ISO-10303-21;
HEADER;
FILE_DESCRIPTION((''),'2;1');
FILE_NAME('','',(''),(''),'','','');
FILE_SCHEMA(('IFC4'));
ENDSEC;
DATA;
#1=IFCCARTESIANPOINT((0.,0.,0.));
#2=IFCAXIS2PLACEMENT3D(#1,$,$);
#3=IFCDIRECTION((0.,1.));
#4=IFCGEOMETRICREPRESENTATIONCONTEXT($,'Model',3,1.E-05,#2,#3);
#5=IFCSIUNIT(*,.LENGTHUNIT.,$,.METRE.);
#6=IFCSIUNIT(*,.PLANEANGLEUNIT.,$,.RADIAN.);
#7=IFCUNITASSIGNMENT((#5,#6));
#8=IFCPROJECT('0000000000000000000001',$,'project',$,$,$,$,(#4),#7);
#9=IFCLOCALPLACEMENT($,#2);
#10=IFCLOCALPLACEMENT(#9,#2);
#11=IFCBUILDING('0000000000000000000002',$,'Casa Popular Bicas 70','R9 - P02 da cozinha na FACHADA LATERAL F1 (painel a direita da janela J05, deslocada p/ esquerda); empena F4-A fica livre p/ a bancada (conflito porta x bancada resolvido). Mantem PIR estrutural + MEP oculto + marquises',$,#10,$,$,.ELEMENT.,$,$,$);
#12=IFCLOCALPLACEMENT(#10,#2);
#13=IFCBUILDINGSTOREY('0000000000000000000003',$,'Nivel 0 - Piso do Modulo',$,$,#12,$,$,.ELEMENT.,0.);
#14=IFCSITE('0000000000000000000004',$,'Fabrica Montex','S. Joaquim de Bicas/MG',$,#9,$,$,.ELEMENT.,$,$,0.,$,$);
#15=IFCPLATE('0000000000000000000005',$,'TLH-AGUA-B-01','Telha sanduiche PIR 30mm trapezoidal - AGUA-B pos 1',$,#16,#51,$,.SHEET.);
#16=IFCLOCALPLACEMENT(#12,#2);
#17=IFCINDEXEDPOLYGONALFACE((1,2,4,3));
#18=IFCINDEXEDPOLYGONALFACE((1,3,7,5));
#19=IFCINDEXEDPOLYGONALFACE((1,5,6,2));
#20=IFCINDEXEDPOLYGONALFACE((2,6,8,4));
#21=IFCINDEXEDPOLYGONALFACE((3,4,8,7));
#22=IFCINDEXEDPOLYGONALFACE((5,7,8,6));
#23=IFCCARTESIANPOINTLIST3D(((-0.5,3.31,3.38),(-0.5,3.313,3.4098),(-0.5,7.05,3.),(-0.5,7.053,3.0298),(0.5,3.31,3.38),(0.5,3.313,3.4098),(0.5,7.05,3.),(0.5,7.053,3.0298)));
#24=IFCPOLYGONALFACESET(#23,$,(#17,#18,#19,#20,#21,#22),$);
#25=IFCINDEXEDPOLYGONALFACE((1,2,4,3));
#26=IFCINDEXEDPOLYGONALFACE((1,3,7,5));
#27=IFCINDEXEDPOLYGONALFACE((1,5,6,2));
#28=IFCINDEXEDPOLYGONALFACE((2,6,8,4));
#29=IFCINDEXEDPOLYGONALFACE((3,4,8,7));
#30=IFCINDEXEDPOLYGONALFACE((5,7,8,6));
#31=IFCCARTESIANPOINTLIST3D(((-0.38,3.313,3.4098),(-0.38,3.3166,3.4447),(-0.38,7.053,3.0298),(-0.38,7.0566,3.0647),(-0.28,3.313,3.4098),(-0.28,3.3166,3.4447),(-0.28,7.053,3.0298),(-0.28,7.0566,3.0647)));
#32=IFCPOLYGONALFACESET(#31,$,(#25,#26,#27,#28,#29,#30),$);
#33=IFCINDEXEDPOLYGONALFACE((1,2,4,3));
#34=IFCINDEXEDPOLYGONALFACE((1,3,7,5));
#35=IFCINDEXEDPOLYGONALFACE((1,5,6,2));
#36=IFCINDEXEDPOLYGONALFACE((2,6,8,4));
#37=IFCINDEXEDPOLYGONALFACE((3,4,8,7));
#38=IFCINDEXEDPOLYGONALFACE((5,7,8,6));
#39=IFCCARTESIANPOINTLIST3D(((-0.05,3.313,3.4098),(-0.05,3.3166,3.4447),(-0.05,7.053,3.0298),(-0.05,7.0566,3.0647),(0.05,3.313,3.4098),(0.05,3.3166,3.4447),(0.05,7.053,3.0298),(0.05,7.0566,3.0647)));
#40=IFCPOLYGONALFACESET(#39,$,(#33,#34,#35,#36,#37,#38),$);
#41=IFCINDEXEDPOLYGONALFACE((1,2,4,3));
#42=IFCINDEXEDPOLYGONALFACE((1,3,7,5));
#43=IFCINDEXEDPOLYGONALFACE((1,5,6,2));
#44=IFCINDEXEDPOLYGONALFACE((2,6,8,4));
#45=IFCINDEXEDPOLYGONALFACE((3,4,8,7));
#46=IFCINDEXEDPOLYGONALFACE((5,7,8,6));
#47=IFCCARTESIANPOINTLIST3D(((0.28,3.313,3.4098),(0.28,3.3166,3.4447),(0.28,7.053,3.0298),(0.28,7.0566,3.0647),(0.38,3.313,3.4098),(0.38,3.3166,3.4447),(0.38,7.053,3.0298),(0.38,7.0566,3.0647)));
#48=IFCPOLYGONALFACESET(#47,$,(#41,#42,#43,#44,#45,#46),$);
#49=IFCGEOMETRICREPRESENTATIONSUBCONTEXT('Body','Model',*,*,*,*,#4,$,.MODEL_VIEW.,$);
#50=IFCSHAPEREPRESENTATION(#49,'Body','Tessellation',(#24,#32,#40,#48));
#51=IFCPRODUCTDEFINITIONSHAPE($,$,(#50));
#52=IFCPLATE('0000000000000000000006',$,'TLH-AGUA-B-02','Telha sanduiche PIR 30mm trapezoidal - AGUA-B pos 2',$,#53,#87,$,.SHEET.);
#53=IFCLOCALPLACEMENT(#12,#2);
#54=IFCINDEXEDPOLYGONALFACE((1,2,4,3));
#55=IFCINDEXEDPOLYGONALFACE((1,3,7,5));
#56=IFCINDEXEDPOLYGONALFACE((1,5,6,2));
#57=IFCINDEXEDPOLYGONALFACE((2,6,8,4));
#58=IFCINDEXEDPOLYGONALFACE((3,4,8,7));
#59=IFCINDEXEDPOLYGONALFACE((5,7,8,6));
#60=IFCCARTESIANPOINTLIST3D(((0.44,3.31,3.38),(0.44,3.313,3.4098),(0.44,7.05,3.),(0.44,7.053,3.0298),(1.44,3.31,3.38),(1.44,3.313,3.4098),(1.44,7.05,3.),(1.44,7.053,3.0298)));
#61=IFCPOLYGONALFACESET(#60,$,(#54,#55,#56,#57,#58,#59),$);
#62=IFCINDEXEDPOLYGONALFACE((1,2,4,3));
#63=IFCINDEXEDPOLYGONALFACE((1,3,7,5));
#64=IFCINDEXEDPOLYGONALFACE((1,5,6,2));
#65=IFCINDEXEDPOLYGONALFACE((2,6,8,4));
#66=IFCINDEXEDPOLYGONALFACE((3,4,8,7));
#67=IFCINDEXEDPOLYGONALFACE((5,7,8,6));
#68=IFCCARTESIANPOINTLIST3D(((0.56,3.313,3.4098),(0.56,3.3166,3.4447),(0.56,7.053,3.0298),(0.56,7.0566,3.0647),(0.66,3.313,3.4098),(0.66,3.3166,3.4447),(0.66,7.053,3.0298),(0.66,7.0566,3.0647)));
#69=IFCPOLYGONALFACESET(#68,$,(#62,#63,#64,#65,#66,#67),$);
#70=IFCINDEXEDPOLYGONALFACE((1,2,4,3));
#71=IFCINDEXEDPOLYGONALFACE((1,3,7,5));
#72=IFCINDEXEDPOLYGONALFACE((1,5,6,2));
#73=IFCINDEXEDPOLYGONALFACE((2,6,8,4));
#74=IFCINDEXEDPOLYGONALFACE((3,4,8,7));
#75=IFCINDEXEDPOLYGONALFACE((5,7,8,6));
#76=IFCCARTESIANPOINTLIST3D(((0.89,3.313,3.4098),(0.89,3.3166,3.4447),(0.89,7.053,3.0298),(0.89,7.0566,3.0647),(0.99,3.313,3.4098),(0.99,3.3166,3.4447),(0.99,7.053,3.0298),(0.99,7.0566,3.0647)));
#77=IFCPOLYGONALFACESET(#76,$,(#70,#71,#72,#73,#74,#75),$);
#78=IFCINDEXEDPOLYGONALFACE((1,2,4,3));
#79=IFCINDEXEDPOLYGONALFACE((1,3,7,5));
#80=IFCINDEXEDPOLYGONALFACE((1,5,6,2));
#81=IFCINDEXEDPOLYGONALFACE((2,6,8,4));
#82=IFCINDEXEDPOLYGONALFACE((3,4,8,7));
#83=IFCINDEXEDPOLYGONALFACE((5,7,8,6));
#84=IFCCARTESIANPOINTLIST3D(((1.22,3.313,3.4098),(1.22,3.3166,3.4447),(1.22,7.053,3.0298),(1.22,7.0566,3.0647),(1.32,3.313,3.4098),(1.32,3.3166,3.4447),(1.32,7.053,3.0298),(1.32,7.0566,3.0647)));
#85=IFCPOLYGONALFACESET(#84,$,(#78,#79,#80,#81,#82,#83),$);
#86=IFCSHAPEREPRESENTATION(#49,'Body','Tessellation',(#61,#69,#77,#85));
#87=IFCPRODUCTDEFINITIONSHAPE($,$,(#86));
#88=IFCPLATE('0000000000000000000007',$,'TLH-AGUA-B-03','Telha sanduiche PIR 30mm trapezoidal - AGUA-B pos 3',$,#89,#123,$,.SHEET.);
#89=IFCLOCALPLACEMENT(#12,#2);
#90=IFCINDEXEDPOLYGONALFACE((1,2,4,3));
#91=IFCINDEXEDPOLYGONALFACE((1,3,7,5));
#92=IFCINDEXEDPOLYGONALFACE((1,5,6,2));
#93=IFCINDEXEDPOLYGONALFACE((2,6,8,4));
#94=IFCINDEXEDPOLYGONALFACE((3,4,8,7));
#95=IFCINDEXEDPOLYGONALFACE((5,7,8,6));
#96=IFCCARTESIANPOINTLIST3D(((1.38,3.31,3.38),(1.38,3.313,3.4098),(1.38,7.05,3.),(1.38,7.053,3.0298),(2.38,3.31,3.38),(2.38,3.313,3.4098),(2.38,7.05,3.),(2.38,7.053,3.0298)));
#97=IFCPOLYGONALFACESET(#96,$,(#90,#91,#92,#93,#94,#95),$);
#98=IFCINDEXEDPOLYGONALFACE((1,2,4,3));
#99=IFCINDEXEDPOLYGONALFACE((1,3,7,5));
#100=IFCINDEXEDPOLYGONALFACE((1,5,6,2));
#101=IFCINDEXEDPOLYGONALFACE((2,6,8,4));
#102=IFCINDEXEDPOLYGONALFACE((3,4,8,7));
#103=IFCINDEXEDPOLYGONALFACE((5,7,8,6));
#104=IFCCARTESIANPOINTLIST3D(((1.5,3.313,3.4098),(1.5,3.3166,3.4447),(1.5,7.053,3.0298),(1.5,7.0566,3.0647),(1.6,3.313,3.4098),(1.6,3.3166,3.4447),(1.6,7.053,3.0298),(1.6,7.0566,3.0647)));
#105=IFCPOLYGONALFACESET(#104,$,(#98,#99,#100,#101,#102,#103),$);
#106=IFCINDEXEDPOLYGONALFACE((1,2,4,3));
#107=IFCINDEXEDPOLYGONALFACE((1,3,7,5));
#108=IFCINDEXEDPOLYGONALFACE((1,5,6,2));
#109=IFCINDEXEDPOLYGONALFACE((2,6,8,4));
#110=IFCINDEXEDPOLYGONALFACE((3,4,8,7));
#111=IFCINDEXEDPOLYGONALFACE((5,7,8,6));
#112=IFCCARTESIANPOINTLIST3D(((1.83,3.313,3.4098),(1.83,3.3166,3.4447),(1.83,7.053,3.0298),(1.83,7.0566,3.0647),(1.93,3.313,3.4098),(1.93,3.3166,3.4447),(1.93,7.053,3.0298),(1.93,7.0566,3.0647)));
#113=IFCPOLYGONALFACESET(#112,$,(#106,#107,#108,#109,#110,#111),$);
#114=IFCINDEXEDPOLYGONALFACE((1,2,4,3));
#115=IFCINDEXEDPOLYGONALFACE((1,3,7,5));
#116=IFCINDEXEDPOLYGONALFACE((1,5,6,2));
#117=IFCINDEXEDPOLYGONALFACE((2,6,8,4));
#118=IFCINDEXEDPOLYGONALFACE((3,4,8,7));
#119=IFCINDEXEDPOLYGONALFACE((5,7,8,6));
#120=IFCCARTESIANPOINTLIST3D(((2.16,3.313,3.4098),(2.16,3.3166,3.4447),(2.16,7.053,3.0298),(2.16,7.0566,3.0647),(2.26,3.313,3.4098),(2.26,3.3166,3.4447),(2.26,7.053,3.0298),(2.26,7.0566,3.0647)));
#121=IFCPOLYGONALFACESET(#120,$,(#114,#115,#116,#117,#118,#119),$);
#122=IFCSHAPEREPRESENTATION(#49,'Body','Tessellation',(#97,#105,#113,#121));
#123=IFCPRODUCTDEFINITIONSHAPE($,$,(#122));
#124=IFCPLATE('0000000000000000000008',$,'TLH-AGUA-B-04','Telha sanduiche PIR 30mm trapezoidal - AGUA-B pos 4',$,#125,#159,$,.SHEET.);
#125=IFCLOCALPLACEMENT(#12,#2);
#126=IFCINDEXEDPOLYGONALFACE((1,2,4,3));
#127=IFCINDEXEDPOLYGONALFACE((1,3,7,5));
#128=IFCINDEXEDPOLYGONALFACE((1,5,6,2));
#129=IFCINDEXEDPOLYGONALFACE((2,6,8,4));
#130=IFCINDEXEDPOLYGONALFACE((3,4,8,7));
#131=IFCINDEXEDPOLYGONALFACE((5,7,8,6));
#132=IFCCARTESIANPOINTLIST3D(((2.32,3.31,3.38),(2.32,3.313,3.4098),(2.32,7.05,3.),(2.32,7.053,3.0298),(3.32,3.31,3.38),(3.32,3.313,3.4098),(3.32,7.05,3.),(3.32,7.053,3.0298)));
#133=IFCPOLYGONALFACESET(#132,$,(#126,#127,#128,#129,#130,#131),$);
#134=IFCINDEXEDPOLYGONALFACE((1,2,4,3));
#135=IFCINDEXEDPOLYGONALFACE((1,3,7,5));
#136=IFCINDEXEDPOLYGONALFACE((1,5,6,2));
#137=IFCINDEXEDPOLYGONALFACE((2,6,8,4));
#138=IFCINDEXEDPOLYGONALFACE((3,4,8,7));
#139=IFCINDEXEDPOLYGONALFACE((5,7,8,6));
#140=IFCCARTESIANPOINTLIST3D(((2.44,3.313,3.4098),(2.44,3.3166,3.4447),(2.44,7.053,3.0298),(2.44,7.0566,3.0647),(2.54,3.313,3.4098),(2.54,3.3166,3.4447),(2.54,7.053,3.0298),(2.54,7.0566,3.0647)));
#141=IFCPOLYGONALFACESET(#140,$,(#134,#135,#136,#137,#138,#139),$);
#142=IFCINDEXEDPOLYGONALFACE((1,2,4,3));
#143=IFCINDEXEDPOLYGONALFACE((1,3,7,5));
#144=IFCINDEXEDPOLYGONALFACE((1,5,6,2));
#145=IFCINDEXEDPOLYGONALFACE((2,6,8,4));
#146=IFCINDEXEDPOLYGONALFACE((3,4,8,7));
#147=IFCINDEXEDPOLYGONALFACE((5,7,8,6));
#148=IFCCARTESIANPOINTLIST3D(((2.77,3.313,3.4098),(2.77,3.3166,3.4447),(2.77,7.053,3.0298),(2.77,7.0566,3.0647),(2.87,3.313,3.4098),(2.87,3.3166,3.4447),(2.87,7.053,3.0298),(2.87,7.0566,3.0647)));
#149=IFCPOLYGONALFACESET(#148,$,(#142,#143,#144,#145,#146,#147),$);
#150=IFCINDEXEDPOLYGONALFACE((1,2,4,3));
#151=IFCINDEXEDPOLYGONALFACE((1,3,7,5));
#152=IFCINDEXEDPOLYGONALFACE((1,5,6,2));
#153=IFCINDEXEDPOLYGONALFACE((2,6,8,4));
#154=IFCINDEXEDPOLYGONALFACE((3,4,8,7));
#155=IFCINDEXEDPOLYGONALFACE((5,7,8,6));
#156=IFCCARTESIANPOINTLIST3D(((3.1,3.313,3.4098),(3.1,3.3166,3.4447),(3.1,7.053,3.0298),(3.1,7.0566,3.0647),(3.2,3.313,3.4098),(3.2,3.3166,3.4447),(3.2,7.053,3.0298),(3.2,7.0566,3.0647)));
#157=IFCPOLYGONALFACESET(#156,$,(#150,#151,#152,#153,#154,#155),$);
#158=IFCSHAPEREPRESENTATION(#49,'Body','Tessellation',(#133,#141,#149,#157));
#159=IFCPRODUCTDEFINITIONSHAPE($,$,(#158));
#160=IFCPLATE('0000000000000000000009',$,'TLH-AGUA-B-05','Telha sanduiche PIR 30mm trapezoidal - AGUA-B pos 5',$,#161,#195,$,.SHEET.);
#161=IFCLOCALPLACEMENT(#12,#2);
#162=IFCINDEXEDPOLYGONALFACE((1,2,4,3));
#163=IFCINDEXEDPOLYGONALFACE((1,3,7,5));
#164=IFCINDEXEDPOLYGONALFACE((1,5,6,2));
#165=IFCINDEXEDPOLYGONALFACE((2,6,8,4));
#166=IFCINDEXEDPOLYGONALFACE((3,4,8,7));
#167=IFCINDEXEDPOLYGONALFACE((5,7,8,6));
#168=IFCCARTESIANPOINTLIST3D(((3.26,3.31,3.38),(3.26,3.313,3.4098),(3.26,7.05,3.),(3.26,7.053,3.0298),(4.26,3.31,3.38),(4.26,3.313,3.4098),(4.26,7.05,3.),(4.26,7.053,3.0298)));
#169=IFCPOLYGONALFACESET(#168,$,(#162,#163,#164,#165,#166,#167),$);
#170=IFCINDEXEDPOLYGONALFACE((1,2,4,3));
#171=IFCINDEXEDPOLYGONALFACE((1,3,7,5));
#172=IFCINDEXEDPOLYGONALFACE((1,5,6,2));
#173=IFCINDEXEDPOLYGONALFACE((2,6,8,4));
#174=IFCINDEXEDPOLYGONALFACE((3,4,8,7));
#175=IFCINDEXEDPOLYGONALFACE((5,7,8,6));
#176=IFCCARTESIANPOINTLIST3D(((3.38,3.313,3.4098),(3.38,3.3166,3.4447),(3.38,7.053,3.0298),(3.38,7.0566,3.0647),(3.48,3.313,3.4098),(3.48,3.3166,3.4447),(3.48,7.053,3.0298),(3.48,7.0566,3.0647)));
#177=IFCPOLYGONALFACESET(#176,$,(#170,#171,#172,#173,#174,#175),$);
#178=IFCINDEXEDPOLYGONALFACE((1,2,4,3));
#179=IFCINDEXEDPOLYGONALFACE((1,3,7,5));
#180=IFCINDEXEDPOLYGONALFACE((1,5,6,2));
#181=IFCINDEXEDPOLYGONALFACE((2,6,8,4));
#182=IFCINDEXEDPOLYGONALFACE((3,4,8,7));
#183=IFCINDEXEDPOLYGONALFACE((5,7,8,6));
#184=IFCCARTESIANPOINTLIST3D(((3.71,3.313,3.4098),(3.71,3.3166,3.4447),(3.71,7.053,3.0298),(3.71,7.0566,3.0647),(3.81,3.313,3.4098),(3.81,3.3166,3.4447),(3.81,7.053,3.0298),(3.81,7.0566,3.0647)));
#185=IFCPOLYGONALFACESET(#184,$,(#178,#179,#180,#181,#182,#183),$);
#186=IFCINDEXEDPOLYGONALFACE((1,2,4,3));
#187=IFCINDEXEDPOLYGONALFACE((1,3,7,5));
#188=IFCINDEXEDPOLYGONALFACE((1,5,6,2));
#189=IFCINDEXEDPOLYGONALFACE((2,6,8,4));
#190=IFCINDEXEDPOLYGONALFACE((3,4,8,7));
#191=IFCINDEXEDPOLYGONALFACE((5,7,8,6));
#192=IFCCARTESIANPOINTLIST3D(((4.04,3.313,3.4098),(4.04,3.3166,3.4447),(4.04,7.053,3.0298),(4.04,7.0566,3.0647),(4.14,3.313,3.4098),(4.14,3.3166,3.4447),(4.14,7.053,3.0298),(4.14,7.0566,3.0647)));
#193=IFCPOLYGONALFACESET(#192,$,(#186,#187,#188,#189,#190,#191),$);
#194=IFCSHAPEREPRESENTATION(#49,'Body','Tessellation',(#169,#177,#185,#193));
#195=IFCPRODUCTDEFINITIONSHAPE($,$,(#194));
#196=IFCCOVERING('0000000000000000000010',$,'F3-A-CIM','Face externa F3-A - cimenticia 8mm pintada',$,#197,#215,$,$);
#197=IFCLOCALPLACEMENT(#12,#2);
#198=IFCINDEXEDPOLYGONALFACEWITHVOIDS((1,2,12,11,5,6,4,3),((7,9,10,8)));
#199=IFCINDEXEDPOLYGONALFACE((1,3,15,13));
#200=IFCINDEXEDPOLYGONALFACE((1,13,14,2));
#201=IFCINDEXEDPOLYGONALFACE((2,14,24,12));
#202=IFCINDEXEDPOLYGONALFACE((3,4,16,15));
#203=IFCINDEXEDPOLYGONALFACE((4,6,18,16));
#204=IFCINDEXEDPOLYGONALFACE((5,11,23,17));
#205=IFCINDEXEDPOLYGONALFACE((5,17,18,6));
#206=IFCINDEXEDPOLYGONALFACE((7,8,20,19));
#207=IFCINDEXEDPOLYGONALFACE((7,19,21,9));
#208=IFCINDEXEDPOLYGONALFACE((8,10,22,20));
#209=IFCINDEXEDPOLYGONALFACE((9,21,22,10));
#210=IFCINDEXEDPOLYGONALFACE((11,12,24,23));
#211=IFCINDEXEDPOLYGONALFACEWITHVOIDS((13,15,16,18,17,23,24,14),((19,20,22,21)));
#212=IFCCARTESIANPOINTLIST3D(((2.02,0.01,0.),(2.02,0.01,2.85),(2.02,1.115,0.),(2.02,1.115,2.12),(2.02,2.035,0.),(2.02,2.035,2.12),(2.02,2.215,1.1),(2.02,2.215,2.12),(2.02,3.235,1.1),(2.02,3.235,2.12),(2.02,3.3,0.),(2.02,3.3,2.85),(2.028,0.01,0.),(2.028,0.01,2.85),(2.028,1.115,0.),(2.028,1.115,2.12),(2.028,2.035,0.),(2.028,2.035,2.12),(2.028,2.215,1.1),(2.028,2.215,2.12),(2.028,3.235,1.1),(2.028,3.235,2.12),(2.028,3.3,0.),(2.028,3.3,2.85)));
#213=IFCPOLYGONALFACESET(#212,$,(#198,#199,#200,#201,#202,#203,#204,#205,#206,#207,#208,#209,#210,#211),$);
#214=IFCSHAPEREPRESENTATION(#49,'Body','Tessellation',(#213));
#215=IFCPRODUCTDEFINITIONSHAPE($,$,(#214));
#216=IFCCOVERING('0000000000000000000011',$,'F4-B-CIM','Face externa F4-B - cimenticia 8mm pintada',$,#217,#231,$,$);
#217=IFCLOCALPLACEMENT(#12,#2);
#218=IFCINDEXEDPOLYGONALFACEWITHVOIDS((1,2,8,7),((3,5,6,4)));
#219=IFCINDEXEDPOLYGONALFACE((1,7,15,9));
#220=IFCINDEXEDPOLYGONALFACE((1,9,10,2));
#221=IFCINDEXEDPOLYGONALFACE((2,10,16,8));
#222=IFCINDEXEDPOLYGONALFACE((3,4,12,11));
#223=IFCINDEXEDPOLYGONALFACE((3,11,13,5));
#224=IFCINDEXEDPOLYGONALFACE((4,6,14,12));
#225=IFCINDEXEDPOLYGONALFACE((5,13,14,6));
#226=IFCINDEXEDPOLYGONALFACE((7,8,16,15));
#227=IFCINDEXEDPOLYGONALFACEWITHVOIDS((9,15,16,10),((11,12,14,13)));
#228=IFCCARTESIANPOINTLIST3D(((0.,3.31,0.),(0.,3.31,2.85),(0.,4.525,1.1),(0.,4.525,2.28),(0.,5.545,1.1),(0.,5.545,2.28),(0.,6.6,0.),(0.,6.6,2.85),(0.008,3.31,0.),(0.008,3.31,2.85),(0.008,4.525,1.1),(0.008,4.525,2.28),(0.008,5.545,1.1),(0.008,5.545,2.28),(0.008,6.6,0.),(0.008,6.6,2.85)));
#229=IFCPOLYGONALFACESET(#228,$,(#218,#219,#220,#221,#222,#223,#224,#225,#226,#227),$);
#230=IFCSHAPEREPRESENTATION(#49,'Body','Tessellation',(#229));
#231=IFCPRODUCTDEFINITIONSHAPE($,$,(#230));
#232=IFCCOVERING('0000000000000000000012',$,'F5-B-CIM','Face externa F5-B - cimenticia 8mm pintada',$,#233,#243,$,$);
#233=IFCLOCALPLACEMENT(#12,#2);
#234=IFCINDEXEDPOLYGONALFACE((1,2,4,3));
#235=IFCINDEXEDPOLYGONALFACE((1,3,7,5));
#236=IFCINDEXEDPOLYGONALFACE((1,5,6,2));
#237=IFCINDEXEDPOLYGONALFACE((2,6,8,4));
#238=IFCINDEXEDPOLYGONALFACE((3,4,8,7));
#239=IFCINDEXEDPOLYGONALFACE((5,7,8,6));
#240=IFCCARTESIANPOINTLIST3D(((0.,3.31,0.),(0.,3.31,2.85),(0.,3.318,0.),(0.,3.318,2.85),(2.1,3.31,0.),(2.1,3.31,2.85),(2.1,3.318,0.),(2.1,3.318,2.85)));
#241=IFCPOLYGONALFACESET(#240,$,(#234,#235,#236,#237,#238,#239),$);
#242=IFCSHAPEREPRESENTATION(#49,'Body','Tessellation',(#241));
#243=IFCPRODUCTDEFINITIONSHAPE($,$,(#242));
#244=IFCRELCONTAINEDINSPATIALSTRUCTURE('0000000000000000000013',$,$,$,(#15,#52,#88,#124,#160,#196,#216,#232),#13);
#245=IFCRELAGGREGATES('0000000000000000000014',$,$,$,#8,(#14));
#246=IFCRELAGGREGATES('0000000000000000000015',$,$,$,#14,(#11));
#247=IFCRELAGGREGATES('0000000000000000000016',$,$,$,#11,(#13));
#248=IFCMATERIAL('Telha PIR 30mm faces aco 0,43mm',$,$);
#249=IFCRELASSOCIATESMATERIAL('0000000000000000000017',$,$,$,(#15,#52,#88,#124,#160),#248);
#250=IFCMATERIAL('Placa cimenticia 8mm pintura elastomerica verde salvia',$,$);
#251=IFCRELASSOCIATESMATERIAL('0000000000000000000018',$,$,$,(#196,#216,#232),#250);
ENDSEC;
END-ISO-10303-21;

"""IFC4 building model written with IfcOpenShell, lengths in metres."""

from ifc_helpers import new_model, si_unit, direction, frame, frame_2d, origin, place, context, subcontext, project, spatial, rectangle, extrude, material, element, save


model = new_model("IFC4")

# Units and contexts
model_context = context("Model", 3, precision=1e-05, world=origin(), true_north=direction((0.0, 1.0)))
body_context = subcontext(model_context, "Body", "Model", "MODEL_VIEW")
ifc_project = project(units=[si_unit("LENGTHUNIT", "METRE"), si_unit("PLANEANGLEUNIT", "RADIAN")], contexts=[model_context])

# Site, building, storey
site_placement = place(None, origin())
site = spatial("IfcSite", under=ifc_project, at=site_placement, Name="Fabrica Montex", Description="S. Joaquim de Bicas/MG", CompositionType="ELEMENT", RefElevation=0.0)
building_placement = place(site_placement, origin())
building = spatial("IfcBuilding", under=site, at=building_placement, Name="Casa Popular Bicas 70", Description="R9 - P02 da cozinha na FACHADA LATERAL F1 (painel a direita da janela J05, deslocada p/ esquerda); empena F4-A fica livre p/ a bancada (conflito porta x bancada resolvido). Mantem PIR estrutural + MEP oculto + marquises", CompositionType="ELEMENT")
storey_placement = place(building_placement, origin())
storey = spatial("IfcBuildingStorey", under=building, at=storey_placement, Name="Nivel 0 - Piso do Modulo", CompositionType="ELEMENT", Elevation=0.0)

# Plates
ifc_material_1 = material(Name="Telha PIR 30mm faces aco 0,43mm")
for number, where, z_axis, x_axis, name, description in (
    (1, (-0.5, 3.31, 3.38), (0.0, 0.101084, 0.994878), (1.0, 0.0, 0.0), "TLH-AGUA-B-01", "Telha sanduiche PIR 30mm trapezoidal - AGUA-B pos 1"),
    (2, (0.44, 3.31, 3.38), (0.0, 0.101084, 0.994878), (1.0, 0.0, 0.0), "TLH-AGUA-B-02", "Telha sanduiche PIR 30mm trapezoidal - AGUA-B pos 2"),
    (3, (1.38, 3.31, 3.38), (0.0, 0.101084, 0.994878), (1.0, 0.0, 0.0), "TLH-AGUA-B-03", "Telha sanduiche PIR 30mm trapezoidal - AGUA-B pos 3"),
    (4, (2.32, 3.31, 3.38), (0.0, 0.101084, 0.994878), (1.0, 0.0, 0.0), "TLH-AGUA-B-04", "Telha sanduiche PIR 30mm trapezoidal - AGUA-B pos 4"),
    (5, (3.26, 3.31, 3.38), (0.0, 0.101084, 0.994878), (1.0, 0.0, 0.0), "TLH-AGUA-B-05", "Telha sanduiche PIR 30mm trapezoidal - AGUA-B pos 5"),
):
    element("IfcPlate", number, at=place(storey_placement, frame(where, z_axis=z_axis, x_axis=x_axis)), inside=storey, material=ifc_material_1, Name=name, Description=description, PredefinedType="SHEET", context=body_context, shape_type="SweptSolid", body=[
        extrude(rectangle(XDim=1.0, YDim=3.7593, at=frame_2d((0.5, 1.8796))), origin(), (0.0, 0.0, 1.0), 0.03),
        extrude(rectangle(XDim=0.1, YDim=3.7593, at=frame_2d((0.17, 1.8796))), frame((0.0, 0.0, 0.03)), (0.0, 0.0, 1.0), 0.035),
        extrude(rectangle(XDim=0.1, YDim=3.7593, at=frame_2d((0.5, 1.8796))), frame((0.0, 0.0, 0.03)), (0.0, 0.0, 1.0), 0.035),
        extrude(rectangle(XDim=0.1, YDim=3.7593, at=frame_2d((0.83, 1.8796))), frame((0.0, 0.0, 0.03)), (0.0, 0.0, 1.0), 0.035),
    ])

# Covering, openings
ifc_material_2 = material(Name="Placa cimenticia 8mm pintura elastomerica verde salvia")
covering_1_placement = place(None, frame((2.024, 3.3, 0.0), z_axis=(0.0, 0.0, 1.0), x_axis=(0.0, -1.0, 0.0)))
covering_1 = element("IfcCovering", 6, at=covering_1_placement, inside=storey, material=ifc_material_2, Name="F3-A-CIM", Description="Face externa F3-A - cimenticia 8mm pintada", context=body_context, shape_type="SweptSolid", body=[
    extrude(rectangle(XDim=3.29, YDim=0.008, at=frame_2d((1.645, 0.0))), origin(), (0.0, 0.0, 1.0), 2.85),
])
opening_1_placement = place(None, frame((2.024, 3.225, 1.1), z_axis=(0.0, 0.0, 1.0), x_axis=(0.0, -1.0, 0.0)))
element("IfcOpeningElement", 7, at=opening_1_placement, cuts=covering_1, PredefinedType="OPENING", context=body_context, shape_type="SweptSolid", body=[
    extrude(rectangle(XDim=1.02, YDim=0.03, at=frame_2d((0.5, 0.0))), origin(), (0.0, 0.0, 1.0), 1.02),
])
opening_2_placement = place(None, frame((2.024, 2.025, 0.0), z_axis=(0.0, 0.0, 1.0), x_axis=(0.0, -1.0, 0.0)))
element("IfcOpeningElement", 8, at=opening_2_placement, cuts=covering_1, PredefinedType="OPENING", context=body_context, shape_type="SweptSolid", body=[
    extrude(rectangle(XDim=0.92, YDim=0.03, at=frame_2d((0.45, 0.0))), origin(), (0.0, 0.0, 1.0), 2.12),
])

# Covering, opening
covering_2_placement = place(storey_placement, frame((0.004, 3.31, 0.0), x_axis=(0.0, 1.0, 0.0)))
covering_2 = element("IfcCovering", 9, at=covering_2_placement, inside=storey, material=ifc_material_2, Name="F4-B-CIM", Description="Face externa F4-B - cimenticia 8mm pintada", context=body_context, shape_type="SweptSolid", body=[
    extrude(rectangle(XDim=3.29, YDim=0.008, at=frame_2d((1.645, 0.0))), origin(), (0.0, 0.0, 1.0), 2.85),
])
opening_3_placement = place(storey_placement, frame((0.004, 4.535, 1.1), x_axis=(0.0, 1.0, 0.0)))
element("IfcOpeningElement", 10, at=opening_3_placement, cuts=covering_2, PredefinedType="OPENING", context=body_context, shape_type="SweptSolid", body=[
    extrude(rectangle(XDim=1.02, YDim=0.03, at=frame_2d((0.5, 0.0))), origin(), (0.0, 0.0, 1.0), 1.18),
])

# Covering
covering_3_placement = place(storey_placement, frame((0.0, 3.314, 0.0), x_axis=(1.0, 0.0, 0.0)))
element("IfcCovering", 11, at=covering_3_placement, inside=storey, material=ifc_material_2, Name="F5-B-CIM", Description="Face externa F5-B - cimenticia 8mm pintada", context=body_context, shape_type="SweptSolid", body=[
    extrude(rectangle(XDim=2.1, YDim=0.008, at=frame_2d((1.05, 0.0))), origin(), (0.0, 0.0, 1.0), 2.85),
])

save(model, "model.ifc")
